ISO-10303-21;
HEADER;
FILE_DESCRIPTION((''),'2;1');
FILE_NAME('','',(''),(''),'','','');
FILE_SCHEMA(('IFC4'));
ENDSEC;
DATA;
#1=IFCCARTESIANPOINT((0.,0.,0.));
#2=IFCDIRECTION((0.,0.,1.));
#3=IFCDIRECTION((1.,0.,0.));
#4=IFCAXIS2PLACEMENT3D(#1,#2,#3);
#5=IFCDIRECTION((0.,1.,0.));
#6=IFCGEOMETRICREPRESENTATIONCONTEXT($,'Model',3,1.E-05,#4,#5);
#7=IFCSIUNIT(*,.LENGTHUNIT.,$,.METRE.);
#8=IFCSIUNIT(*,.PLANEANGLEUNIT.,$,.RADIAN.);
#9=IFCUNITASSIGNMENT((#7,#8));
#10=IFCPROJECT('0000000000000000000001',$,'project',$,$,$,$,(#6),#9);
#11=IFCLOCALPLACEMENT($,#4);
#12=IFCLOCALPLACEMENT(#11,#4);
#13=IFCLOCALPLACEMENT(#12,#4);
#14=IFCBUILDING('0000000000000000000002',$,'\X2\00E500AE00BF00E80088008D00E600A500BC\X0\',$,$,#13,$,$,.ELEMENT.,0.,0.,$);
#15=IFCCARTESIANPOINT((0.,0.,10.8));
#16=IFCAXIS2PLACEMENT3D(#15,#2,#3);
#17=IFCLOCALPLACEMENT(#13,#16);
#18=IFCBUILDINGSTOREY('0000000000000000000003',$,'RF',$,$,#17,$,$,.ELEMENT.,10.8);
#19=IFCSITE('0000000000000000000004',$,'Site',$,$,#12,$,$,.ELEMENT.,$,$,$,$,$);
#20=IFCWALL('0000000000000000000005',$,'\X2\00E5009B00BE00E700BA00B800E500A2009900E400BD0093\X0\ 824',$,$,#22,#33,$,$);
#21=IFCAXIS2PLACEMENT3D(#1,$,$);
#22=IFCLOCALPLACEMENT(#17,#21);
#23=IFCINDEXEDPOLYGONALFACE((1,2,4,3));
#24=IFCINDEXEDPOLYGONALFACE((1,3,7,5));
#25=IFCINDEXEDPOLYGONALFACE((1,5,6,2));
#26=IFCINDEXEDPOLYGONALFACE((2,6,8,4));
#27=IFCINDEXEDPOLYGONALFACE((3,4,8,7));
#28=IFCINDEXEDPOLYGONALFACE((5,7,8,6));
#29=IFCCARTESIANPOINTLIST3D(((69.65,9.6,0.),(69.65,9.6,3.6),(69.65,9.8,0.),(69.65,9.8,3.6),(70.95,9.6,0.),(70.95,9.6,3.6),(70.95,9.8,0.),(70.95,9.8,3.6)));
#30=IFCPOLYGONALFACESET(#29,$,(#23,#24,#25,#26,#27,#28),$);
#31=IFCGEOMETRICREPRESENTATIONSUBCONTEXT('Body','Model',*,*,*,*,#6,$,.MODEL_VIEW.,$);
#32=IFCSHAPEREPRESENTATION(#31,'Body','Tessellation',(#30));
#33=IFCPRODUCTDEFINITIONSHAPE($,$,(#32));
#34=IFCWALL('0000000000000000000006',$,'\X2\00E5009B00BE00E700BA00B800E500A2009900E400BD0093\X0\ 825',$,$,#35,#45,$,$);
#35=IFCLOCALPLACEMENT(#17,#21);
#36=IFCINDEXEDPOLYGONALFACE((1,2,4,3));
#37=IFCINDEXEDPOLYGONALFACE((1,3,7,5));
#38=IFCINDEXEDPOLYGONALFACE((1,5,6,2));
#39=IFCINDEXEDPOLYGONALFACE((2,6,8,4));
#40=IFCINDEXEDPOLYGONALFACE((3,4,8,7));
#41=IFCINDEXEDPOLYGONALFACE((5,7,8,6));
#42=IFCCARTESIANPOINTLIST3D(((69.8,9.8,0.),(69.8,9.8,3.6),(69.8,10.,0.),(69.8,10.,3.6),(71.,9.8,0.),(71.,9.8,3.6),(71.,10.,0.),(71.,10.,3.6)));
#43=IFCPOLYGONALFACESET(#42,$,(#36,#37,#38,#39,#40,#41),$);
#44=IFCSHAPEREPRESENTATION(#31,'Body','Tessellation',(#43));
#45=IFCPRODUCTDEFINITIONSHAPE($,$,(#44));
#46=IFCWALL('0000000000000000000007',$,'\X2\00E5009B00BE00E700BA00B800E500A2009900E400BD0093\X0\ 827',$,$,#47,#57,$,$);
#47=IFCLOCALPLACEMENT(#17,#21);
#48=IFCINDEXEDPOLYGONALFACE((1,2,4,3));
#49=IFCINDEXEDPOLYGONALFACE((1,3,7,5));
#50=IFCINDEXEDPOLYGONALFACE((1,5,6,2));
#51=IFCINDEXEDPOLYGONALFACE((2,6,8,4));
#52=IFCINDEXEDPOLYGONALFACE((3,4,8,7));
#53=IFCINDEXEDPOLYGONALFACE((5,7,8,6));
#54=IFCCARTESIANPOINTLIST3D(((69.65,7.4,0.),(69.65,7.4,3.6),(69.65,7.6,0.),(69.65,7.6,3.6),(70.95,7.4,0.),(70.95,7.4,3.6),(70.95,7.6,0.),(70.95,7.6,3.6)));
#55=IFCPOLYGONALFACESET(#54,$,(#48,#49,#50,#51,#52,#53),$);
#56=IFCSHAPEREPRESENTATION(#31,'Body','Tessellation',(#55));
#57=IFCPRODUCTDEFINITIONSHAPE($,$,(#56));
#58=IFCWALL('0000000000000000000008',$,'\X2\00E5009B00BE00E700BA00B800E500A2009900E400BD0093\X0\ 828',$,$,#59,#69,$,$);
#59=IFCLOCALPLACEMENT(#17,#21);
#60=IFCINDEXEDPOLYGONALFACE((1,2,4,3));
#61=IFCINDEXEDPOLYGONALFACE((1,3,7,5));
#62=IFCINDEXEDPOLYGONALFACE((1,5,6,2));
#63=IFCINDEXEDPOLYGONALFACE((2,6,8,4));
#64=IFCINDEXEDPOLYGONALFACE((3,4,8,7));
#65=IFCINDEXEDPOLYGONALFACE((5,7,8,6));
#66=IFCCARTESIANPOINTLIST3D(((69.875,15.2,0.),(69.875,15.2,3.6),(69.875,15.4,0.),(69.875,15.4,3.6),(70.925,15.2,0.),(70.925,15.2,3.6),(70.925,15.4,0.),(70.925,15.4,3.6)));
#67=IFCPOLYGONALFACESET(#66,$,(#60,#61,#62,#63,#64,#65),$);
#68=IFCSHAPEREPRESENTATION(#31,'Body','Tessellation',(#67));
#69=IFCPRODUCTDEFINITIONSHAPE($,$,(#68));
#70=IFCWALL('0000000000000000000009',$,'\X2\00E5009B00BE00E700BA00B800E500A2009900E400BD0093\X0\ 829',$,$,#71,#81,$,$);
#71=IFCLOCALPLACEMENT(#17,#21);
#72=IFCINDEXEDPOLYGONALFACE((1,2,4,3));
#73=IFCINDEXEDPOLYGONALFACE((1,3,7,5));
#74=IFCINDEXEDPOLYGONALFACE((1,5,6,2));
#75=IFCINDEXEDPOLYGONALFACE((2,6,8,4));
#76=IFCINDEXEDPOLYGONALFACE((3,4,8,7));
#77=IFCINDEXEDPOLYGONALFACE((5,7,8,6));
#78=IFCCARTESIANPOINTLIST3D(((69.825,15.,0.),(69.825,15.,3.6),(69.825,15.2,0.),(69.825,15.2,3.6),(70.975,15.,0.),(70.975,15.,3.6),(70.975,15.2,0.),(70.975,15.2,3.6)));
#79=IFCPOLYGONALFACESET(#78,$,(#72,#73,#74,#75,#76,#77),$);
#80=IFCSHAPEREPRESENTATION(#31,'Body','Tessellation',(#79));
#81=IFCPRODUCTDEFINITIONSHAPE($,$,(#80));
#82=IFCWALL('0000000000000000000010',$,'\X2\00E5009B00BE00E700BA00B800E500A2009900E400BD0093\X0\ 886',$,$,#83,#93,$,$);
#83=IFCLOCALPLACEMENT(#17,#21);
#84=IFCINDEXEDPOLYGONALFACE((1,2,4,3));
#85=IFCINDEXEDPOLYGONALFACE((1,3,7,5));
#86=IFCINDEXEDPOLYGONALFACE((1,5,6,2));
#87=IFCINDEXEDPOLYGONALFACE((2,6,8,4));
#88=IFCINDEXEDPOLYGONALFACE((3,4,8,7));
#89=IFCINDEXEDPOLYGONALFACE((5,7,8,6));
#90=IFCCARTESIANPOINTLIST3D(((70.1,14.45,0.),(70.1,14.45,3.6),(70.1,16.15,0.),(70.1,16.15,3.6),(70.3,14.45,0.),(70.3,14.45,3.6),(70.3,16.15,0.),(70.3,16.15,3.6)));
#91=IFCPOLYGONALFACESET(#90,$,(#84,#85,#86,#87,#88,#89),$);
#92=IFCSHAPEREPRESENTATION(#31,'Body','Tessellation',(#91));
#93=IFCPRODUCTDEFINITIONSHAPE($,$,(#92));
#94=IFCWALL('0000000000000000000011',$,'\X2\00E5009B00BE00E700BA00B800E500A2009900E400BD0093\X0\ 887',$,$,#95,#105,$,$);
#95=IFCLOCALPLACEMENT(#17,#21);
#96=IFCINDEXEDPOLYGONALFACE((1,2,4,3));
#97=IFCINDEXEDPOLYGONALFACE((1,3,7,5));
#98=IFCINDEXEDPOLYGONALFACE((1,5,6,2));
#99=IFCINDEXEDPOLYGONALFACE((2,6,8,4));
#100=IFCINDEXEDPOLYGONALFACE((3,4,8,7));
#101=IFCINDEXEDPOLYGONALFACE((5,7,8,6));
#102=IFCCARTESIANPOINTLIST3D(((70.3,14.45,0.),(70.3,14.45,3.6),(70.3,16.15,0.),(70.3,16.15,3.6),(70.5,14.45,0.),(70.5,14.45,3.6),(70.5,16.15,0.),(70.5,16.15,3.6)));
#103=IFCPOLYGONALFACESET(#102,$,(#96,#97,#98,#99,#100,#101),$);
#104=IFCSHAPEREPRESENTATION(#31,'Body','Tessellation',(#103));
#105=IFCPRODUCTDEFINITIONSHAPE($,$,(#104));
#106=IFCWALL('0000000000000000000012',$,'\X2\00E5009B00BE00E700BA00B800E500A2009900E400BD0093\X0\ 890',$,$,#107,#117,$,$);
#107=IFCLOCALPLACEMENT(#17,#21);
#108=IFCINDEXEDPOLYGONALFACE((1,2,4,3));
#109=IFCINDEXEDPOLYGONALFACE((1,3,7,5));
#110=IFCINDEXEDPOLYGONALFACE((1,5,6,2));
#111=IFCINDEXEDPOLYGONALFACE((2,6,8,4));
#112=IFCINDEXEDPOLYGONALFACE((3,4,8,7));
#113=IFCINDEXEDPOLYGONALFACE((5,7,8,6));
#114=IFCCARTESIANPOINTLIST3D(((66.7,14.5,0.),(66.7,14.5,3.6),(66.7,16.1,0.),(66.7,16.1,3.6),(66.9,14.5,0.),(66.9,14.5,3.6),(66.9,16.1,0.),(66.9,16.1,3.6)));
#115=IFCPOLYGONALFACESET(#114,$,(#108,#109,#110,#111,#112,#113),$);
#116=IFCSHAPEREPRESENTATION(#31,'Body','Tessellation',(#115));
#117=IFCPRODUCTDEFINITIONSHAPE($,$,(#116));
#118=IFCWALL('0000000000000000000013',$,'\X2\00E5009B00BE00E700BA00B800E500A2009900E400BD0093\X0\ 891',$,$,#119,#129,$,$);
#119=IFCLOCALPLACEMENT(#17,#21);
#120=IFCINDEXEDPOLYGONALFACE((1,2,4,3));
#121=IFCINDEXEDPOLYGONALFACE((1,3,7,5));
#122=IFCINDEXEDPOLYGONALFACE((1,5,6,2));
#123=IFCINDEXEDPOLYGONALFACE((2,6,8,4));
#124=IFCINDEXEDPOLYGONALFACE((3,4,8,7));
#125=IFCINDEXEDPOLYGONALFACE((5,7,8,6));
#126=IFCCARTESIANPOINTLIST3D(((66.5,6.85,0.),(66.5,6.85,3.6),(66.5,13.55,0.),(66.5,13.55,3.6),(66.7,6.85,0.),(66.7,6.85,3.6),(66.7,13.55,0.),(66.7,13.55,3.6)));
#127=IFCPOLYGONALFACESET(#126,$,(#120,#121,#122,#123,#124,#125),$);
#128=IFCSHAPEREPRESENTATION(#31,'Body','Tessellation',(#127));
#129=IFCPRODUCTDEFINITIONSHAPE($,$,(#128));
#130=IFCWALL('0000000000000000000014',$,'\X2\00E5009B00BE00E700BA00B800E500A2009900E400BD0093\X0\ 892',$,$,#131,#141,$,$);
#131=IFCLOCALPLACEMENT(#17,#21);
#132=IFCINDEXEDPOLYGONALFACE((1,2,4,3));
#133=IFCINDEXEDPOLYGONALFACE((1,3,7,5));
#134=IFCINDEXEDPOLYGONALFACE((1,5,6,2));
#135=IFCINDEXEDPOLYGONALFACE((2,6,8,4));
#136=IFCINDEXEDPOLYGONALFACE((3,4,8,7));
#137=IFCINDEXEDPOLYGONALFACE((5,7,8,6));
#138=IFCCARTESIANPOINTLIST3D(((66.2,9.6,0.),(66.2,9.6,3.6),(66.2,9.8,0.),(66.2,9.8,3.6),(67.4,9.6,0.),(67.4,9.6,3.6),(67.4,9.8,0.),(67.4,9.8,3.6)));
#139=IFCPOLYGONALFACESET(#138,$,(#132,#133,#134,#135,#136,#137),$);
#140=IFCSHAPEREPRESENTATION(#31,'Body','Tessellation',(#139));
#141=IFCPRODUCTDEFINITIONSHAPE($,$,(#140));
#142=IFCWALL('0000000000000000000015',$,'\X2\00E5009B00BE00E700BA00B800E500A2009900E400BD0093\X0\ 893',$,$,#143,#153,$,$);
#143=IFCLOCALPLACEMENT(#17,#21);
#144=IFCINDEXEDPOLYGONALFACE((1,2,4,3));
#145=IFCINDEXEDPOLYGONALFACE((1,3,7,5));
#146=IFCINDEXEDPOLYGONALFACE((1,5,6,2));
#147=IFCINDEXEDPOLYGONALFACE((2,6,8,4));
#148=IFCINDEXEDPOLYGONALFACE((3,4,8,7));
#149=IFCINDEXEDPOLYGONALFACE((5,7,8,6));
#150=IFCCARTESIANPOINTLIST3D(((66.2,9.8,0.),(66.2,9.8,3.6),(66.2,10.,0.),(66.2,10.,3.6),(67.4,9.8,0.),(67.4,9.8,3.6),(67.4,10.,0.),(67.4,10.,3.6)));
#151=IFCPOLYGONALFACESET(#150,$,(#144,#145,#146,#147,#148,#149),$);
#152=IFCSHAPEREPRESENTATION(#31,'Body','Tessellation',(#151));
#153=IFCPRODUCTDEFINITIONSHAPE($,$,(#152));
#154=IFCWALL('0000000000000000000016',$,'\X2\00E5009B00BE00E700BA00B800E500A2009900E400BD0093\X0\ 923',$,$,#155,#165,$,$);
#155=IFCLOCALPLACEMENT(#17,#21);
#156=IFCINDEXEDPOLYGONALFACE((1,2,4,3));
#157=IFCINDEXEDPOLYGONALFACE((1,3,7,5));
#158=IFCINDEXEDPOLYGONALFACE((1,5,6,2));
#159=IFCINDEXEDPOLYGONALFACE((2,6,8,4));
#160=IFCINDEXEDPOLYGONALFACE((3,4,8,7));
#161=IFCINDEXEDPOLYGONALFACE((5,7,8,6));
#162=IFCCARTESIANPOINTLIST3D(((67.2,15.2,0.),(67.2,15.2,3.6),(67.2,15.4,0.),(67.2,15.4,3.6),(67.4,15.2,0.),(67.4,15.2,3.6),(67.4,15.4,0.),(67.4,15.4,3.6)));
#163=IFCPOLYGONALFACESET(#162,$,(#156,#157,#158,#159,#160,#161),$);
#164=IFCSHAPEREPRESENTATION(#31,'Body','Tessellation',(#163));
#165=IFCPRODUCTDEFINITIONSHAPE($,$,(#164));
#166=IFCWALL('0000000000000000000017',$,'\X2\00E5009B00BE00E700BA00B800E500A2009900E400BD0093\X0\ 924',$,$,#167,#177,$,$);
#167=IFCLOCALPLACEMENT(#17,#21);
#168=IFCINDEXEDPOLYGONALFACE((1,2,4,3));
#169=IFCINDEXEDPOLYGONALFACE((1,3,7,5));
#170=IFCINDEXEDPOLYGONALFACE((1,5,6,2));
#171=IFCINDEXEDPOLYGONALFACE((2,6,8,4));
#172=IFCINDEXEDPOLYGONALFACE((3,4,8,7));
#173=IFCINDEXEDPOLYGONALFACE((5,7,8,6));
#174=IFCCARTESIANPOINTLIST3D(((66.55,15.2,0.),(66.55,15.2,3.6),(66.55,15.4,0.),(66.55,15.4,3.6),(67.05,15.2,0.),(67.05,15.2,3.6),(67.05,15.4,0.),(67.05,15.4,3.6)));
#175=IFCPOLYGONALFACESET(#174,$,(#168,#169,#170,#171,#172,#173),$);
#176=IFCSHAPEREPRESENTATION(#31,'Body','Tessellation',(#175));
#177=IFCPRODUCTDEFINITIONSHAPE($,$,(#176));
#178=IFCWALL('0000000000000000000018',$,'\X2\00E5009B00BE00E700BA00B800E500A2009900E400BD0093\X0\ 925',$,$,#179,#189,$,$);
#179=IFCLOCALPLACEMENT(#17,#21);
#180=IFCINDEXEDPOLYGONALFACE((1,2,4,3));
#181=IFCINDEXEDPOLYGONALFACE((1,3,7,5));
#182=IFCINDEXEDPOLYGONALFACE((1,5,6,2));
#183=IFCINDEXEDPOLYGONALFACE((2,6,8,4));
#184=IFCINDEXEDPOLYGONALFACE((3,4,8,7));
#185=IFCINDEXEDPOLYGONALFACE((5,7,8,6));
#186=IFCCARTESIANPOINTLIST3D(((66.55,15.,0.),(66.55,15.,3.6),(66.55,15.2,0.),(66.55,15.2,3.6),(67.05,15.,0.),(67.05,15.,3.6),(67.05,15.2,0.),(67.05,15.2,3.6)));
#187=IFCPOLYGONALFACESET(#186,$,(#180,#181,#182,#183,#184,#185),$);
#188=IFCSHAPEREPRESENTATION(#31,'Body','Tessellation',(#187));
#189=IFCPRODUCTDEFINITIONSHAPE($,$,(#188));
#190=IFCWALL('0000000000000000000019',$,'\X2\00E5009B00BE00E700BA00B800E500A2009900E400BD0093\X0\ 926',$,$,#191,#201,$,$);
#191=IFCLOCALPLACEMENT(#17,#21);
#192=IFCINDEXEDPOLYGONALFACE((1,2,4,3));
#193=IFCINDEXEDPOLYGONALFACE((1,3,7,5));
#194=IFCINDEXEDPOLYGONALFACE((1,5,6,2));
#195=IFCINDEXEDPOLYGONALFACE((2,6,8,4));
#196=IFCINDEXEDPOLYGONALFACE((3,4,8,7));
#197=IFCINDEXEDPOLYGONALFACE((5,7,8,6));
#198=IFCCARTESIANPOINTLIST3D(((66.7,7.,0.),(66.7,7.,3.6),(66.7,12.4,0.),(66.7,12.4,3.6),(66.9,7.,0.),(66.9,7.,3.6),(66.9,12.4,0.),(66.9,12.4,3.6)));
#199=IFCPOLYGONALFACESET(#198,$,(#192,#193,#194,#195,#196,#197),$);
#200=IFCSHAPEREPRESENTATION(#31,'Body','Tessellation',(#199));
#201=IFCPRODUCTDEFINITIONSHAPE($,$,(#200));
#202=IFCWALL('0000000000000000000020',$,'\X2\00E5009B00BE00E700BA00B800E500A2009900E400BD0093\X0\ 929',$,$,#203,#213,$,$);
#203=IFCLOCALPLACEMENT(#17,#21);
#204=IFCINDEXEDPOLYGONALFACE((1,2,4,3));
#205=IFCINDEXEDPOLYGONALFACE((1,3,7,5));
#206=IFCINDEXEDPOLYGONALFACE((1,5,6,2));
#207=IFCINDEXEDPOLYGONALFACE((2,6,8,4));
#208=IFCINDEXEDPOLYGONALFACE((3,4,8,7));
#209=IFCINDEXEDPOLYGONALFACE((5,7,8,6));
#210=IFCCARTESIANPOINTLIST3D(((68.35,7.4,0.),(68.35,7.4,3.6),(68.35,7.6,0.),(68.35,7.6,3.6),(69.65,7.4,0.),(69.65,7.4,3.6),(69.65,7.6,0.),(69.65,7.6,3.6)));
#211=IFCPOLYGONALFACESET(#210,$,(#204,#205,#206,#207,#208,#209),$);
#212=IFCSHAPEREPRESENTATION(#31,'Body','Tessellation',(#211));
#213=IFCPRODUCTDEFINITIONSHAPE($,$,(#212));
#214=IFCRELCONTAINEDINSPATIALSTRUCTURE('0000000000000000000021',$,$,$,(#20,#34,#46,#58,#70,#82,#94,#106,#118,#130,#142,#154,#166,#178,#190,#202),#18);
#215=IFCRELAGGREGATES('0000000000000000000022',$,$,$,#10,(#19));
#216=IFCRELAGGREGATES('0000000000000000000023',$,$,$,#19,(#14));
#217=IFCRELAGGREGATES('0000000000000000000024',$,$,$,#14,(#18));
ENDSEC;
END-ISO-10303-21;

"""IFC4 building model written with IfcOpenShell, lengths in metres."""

from ifc_helpers import new_model, si_unit, direction, frame, frame_2d, origin_with_axes, place, context, subcontext, project, spatial, rectangle, extrude, element, save


model = new_model("IFC4")

# Units and contexts
model_context = context("Model", 3, precision=1e-05, world=origin_with_axes(), true_north=direction((0.0, 1.0, 0.0)))
body_context = subcontext(model_context, "Body", "Model", "MODEL_VIEW")
ifc_project = project(units=[si_unit("LENGTHUNIT", "METRE"), si_unit("PLANEANGLEUNIT", "RADIAN")], contexts=[model_context])

# Site, building, storey
placement = place(None, origin_with_axes())
site_placement = place(placement, origin_with_axes())
site = spatial("IfcSite", under=ifc_project, at=site_placement, Name="Site", CompositionType="ELEMENT")
building_placement = place(site_placement, origin_with_axes())
building = spatial("IfcBuilding", under=site, at=building_placement, Name="å®¿è\u0088\u008dæ¥¼", CompositionType="ELEMENT", ElevationOfRefHeight=0.0, ElevationOfTerrain=0.0)
storey_placement = place(building_placement, frame((0.0, 0.0, 10.8), z_axis=(0.0, 0.0, 1.0), x_axis=(1.0, 0.0, 0.0)))
storey = spatial("IfcBuildingStorey", under=building, at=storey_placement, Name="RF", CompositionType="ELEMENT", Elevation=10.8)

# Walls
wall_1_placement = place(storey_placement, frame((70.3, 9.7, 0.0), z_axis=(0.0, 0.0, 1.0), x_axis=(1.0, 0.0, 0.0)))
element("IfcWall", 1, at=wall_1_placement, inside=storey, Name="å\u009b¾çº¸å¢\u0099ä½\u0093 824", context=body_context, shape_type="SweptSolid", body=[
    extrude(rectangle(XDim=1.3, YDim=0.2, at=frame_2d((0.0, 0.0), x_axis=(1.0, 0.0, 0.0))), frame((0.0, 0.0, 0.0), z_axis=(0.0, 0.0, 1.0)), (0.0, 0.0, 1.0), 3.6),
])
wall_2_placement = place(storey_placement, frame((70.4, 9.9, 0.0), z_axis=(0.0, 0.0, 1.0), x_axis=(1.0, 0.0, 0.0)))
element("IfcWall", 2, at=wall_2_placement, inside=storey, Name="å\u009b¾çº¸å¢\u0099ä½\u0093 825", context=body_context, shape_type="SweptSolid", body=[
    extrude(rectangle(XDim=1.2, YDim=0.2, at=frame_2d((0.0, 0.0), x_axis=(1.0, 0.0, 0.0))), frame((0.0, 0.0, 0.0), z_axis=(0.0, 0.0, 1.0)), (0.0, 0.0, 1.0), 3.6),
])
wall_3_placement = place(storey_placement, frame((70.3, 7.5, 0.0), z_axis=(0.0, 0.0, 1.0), x_axis=(1.0, 0.0, 0.0)))
element("IfcWall", 3, at=wall_3_placement, inside=storey, Name="å\u009b¾çº¸å¢\u0099ä½\u0093 827", context=body_context, shape_type="SweptSolid", body=[
    extrude(rectangle(XDim=1.3, YDim=0.2, at=frame_2d((0.0, 0.0), x_axis=(1.0, 0.0, 0.0))), frame((0.0, 0.0, 0.0), z_axis=(0.0, 0.0, 1.0)), (0.0, 0.0, 1.0), 3.6),
])
wall_4_placement = place(storey_placement, frame((70.4, 15.3, 0.0), z_axis=(0.0, 0.0, 1.0), x_axis=(1.0, 0.0, 0.0)))
element("IfcWall", 4, at=wall_4_placement, inside=storey, Name="å\u009b¾çº¸å¢\u0099ä½\u0093 828", context=body_context, shape_type="SweptSolid", body=[
    extrude(rectangle(XDim=1.05, YDim=0.2, at=frame_2d((0.0, 0.0), x_axis=(1.0, 0.0, 0.0))), frame((0.0, 0.0, 0.0), z_axis=(0.0, 0.0, 1.0)), (0.0, 0.0, 1.0), 3.6),
])
wall_5_placement = place(storey_placement, frame((70.4, 15.1, 0.0), z_axis=(0.0, 0.0, 1.0), x_axis=(1.0, 0.0, 0.0)))
element("IfcWall", 5, at=wall_5_placement, inside=storey, Name="å\u009b¾çº¸å¢\u0099ä½\u0093 829", context=body_context, shape_type="SweptSolid", body=[
    extrude(rectangle(XDim=1.15, YDim=0.2, at=frame_2d((0.0, 0.0), x_axis=(1.0, 0.0, 0.0))), frame((0.0, 0.0, 0.0), z_axis=(0.0, 0.0, 1.0)), (0.0, 0.0, 1.0), 3.6),
])
for number, where, z_axis, x_axis, name in (
    (6, (70.2, 15.3, 0.0), (0.0, 0.0, 1.0), (0.0, 1.0, 0.0), "å\u009b¾çº¸å¢\u0099ä½\u0093 886"),
    (7, (70.4, 15.3, 0.0), (0.0, 0.0, 1.0), (0.0, 1.0, 0.0), "å\u009b¾çº¸å¢\u0099ä½\u0093 887"),
):
    element("IfcWall", number, at=place(storey_placement, frame(where, z_axis=z_axis, x_axis=x_axis)), inside=storey, Name=name, context=body_context, shape_type="SweptSolid", body=[
        extrude(rectangle(XDim=1.7, YDim=0.2, at=frame_2d((0.0, 0.0), x_axis=(1.0, 0.0, 0.0))), frame((0.0, 0.0, 0.0), z_axis=(0.0, 0.0, 1.0)), (0.0, 0.0, 1.0), 3.6),
    ])
wall_6_placement = place(storey_placement, frame((66.8, 15.3, 0.0), z_axis=(0.0, 0.0, 1.0), x_axis=(0.0, 1.0, 0.0)))
element("IfcWall", 8, at=wall_6_placement, inside=storey, Name="å\u009b¾çº¸å¢\u0099ä½\u0093 890", context=body_context, shape_type="SweptSolid", body=[
    extrude(rectangle(XDim=1.6, YDim=0.2, at=frame_2d((0.0, 0.0), x_axis=(1.0, 0.0, 0.0))), frame((0.0, 0.0, 0.0), z_axis=(0.0, 0.0, 1.0)), (0.0, 0.0, 1.0), 3.6),
])
wall_7_placement = place(storey_placement, frame((66.6, 10.2, 0.0), z_axis=(0.0, 0.0, 1.0), x_axis=(0.0, 1.0, 0.0)))
element("IfcWall", 9, at=wall_7_placement, inside=storey, Name="å\u009b¾çº¸å¢\u0099ä½\u0093 891", context=body_context, shape_type="SweptSolid", body=[
    extrude(rectangle(XDim=6.7, YDim=0.2, at=frame_2d((0.0, 0.0), x_axis=(1.0, 0.0, 0.0))), frame((0.0, 0.0, 0.0), z_axis=(0.0, 0.0, 1.0)), (0.0, 0.0, 1.0), 3.6),
])
for number, where, z_axis, x_axis, name in (
    (10, (66.8, 9.7, 0.0), (0.0, 0.0, 1.0), (1.0, 0.0, 0.0), "å\u009b¾çº¸å¢\u0099ä½\u0093 892"),
    (11, (66.8, 9.9, 0.0), (0.0, 0.0, 1.0), (1.0, 0.0, 0.0), "å\u009b¾çº¸å¢\u0099ä½\u0093 893"),
):
    element("IfcWall", number, at=place(storey_placement, frame(where, z_axis=z_axis, x_axis=x_axis)), inside=storey, Name=name, context=body_context, shape_type="SweptSolid", body=[
        extrude(rectangle(XDim=1.2, YDim=0.2, at=frame_2d((0.0, 0.0), x_axis=(1.0, 0.0, 0.0))), frame((0.0, 0.0, 0.0), z_axis=(0.0, 0.0, 1.0)), (0.0, 0.0, 1.0), 3.6),
    ])
wall_8_placement = place(storey_placement, frame((67.3, 15.3, 0.0), z_axis=(0.0, 0.0, 1.0), x_axis=(0.0, -1.0, 0.0)))
element("IfcWall", 12, at=wall_8_placement, inside=storey, Name="å\u009b¾çº¸å¢\u0099ä½\u0093 923", context=body_context, shape_type="SweptSolid", body=[
    extrude(rectangle(XDim=0.2, YDim=0.2, at=frame_2d((0.0, 0.0), x_axis=(1.0, 0.0, 0.0))), frame((0.0, 0.0, 0.0), z_axis=(0.0, 0.0, 1.0)), (0.0, 0.0, 1.0), 3.6),
])
for number, where, z_axis, x_axis, name in (
    (13, (66.8, 15.3, 0.0), (0.0, 0.0, 1.0), (1.0, 0.0, 0.0), "å\u009b¾çº¸å¢\u0099ä½\u0093 924"),
    (14, (66.8, 15.1, 0.0), (0.0, 0.0, 1.0), (1.0, 0.0, 0.0), "å\u009b¾çº¸å¢\u0099ä½\u0093 925"),
):
    element("IfcWall", number, at=place(storey_placement, frame(where, z_axis=z_axis, x_axis=x_axis)), inside=storey, Name=name, context=body_context, shape_type="SweptSolid", body=[
        extrude(rectangle(XDim=0.5, YDim=0.2, at=frame_2d((0.0, 0.0), x_axis=(1.0, 0.0, 0.0))), frame((0.0, 0.0, 0.0), z_axis=(0.0, 0.0, 1.0)), (0.0, 0.0, 1.0), 3.6),
    ])
wall_9_placement = place(storey_placement, frame((66.8, 9.7, 0.0), z_axis=(0.0, 0.0, 1.0), x_axis=(0.0, 1.0, 0.0)))
element("IfcWall", 15, at=wall_9_placement, inside=storey, Name="å\u009b¾çº¸å¢\u0099ä½\u0093 926", context=body_context, shape_type="SweptSolid", body=[
    extrude(rectangle(XDim=5.4, YDim=0.2, at=frame_2d((0.0, 0.0), x_axis=(1.0, 0.0, 0.0))), frame((0.0, 0.0, 0.0), z_axis=(0.0, 0.0, 1.0)), (0.0, 0.0, 1.0), 3.6),
])
wall_10_placement = place(storey_placement, frame((69.0, 7.5, 0.0), z_axis=(0.0, 0.0, 1.0), x_axis=(1.0, 0.0, 0.0)))
element("IfcWall", 16, at=wall_10_placement, inside=storey, Name="å\u009b¾çº¸å¢\u0099ä½\u0093 929", context=body_context, shape_type="SweptSolid", body=[
    extrude(rectangle(XDim=1.3, YDim=0.2, at=frame_2d((0.0, 0.0), x_axis=(1.0, 0.0, 0.0))), frame((0.0, 0.0, 0.0), z_axis=(0.0, 0.0, 1.0)), (0.0, 0.0, 1.0), 3.6),
])

save(model, "model.ifc")
